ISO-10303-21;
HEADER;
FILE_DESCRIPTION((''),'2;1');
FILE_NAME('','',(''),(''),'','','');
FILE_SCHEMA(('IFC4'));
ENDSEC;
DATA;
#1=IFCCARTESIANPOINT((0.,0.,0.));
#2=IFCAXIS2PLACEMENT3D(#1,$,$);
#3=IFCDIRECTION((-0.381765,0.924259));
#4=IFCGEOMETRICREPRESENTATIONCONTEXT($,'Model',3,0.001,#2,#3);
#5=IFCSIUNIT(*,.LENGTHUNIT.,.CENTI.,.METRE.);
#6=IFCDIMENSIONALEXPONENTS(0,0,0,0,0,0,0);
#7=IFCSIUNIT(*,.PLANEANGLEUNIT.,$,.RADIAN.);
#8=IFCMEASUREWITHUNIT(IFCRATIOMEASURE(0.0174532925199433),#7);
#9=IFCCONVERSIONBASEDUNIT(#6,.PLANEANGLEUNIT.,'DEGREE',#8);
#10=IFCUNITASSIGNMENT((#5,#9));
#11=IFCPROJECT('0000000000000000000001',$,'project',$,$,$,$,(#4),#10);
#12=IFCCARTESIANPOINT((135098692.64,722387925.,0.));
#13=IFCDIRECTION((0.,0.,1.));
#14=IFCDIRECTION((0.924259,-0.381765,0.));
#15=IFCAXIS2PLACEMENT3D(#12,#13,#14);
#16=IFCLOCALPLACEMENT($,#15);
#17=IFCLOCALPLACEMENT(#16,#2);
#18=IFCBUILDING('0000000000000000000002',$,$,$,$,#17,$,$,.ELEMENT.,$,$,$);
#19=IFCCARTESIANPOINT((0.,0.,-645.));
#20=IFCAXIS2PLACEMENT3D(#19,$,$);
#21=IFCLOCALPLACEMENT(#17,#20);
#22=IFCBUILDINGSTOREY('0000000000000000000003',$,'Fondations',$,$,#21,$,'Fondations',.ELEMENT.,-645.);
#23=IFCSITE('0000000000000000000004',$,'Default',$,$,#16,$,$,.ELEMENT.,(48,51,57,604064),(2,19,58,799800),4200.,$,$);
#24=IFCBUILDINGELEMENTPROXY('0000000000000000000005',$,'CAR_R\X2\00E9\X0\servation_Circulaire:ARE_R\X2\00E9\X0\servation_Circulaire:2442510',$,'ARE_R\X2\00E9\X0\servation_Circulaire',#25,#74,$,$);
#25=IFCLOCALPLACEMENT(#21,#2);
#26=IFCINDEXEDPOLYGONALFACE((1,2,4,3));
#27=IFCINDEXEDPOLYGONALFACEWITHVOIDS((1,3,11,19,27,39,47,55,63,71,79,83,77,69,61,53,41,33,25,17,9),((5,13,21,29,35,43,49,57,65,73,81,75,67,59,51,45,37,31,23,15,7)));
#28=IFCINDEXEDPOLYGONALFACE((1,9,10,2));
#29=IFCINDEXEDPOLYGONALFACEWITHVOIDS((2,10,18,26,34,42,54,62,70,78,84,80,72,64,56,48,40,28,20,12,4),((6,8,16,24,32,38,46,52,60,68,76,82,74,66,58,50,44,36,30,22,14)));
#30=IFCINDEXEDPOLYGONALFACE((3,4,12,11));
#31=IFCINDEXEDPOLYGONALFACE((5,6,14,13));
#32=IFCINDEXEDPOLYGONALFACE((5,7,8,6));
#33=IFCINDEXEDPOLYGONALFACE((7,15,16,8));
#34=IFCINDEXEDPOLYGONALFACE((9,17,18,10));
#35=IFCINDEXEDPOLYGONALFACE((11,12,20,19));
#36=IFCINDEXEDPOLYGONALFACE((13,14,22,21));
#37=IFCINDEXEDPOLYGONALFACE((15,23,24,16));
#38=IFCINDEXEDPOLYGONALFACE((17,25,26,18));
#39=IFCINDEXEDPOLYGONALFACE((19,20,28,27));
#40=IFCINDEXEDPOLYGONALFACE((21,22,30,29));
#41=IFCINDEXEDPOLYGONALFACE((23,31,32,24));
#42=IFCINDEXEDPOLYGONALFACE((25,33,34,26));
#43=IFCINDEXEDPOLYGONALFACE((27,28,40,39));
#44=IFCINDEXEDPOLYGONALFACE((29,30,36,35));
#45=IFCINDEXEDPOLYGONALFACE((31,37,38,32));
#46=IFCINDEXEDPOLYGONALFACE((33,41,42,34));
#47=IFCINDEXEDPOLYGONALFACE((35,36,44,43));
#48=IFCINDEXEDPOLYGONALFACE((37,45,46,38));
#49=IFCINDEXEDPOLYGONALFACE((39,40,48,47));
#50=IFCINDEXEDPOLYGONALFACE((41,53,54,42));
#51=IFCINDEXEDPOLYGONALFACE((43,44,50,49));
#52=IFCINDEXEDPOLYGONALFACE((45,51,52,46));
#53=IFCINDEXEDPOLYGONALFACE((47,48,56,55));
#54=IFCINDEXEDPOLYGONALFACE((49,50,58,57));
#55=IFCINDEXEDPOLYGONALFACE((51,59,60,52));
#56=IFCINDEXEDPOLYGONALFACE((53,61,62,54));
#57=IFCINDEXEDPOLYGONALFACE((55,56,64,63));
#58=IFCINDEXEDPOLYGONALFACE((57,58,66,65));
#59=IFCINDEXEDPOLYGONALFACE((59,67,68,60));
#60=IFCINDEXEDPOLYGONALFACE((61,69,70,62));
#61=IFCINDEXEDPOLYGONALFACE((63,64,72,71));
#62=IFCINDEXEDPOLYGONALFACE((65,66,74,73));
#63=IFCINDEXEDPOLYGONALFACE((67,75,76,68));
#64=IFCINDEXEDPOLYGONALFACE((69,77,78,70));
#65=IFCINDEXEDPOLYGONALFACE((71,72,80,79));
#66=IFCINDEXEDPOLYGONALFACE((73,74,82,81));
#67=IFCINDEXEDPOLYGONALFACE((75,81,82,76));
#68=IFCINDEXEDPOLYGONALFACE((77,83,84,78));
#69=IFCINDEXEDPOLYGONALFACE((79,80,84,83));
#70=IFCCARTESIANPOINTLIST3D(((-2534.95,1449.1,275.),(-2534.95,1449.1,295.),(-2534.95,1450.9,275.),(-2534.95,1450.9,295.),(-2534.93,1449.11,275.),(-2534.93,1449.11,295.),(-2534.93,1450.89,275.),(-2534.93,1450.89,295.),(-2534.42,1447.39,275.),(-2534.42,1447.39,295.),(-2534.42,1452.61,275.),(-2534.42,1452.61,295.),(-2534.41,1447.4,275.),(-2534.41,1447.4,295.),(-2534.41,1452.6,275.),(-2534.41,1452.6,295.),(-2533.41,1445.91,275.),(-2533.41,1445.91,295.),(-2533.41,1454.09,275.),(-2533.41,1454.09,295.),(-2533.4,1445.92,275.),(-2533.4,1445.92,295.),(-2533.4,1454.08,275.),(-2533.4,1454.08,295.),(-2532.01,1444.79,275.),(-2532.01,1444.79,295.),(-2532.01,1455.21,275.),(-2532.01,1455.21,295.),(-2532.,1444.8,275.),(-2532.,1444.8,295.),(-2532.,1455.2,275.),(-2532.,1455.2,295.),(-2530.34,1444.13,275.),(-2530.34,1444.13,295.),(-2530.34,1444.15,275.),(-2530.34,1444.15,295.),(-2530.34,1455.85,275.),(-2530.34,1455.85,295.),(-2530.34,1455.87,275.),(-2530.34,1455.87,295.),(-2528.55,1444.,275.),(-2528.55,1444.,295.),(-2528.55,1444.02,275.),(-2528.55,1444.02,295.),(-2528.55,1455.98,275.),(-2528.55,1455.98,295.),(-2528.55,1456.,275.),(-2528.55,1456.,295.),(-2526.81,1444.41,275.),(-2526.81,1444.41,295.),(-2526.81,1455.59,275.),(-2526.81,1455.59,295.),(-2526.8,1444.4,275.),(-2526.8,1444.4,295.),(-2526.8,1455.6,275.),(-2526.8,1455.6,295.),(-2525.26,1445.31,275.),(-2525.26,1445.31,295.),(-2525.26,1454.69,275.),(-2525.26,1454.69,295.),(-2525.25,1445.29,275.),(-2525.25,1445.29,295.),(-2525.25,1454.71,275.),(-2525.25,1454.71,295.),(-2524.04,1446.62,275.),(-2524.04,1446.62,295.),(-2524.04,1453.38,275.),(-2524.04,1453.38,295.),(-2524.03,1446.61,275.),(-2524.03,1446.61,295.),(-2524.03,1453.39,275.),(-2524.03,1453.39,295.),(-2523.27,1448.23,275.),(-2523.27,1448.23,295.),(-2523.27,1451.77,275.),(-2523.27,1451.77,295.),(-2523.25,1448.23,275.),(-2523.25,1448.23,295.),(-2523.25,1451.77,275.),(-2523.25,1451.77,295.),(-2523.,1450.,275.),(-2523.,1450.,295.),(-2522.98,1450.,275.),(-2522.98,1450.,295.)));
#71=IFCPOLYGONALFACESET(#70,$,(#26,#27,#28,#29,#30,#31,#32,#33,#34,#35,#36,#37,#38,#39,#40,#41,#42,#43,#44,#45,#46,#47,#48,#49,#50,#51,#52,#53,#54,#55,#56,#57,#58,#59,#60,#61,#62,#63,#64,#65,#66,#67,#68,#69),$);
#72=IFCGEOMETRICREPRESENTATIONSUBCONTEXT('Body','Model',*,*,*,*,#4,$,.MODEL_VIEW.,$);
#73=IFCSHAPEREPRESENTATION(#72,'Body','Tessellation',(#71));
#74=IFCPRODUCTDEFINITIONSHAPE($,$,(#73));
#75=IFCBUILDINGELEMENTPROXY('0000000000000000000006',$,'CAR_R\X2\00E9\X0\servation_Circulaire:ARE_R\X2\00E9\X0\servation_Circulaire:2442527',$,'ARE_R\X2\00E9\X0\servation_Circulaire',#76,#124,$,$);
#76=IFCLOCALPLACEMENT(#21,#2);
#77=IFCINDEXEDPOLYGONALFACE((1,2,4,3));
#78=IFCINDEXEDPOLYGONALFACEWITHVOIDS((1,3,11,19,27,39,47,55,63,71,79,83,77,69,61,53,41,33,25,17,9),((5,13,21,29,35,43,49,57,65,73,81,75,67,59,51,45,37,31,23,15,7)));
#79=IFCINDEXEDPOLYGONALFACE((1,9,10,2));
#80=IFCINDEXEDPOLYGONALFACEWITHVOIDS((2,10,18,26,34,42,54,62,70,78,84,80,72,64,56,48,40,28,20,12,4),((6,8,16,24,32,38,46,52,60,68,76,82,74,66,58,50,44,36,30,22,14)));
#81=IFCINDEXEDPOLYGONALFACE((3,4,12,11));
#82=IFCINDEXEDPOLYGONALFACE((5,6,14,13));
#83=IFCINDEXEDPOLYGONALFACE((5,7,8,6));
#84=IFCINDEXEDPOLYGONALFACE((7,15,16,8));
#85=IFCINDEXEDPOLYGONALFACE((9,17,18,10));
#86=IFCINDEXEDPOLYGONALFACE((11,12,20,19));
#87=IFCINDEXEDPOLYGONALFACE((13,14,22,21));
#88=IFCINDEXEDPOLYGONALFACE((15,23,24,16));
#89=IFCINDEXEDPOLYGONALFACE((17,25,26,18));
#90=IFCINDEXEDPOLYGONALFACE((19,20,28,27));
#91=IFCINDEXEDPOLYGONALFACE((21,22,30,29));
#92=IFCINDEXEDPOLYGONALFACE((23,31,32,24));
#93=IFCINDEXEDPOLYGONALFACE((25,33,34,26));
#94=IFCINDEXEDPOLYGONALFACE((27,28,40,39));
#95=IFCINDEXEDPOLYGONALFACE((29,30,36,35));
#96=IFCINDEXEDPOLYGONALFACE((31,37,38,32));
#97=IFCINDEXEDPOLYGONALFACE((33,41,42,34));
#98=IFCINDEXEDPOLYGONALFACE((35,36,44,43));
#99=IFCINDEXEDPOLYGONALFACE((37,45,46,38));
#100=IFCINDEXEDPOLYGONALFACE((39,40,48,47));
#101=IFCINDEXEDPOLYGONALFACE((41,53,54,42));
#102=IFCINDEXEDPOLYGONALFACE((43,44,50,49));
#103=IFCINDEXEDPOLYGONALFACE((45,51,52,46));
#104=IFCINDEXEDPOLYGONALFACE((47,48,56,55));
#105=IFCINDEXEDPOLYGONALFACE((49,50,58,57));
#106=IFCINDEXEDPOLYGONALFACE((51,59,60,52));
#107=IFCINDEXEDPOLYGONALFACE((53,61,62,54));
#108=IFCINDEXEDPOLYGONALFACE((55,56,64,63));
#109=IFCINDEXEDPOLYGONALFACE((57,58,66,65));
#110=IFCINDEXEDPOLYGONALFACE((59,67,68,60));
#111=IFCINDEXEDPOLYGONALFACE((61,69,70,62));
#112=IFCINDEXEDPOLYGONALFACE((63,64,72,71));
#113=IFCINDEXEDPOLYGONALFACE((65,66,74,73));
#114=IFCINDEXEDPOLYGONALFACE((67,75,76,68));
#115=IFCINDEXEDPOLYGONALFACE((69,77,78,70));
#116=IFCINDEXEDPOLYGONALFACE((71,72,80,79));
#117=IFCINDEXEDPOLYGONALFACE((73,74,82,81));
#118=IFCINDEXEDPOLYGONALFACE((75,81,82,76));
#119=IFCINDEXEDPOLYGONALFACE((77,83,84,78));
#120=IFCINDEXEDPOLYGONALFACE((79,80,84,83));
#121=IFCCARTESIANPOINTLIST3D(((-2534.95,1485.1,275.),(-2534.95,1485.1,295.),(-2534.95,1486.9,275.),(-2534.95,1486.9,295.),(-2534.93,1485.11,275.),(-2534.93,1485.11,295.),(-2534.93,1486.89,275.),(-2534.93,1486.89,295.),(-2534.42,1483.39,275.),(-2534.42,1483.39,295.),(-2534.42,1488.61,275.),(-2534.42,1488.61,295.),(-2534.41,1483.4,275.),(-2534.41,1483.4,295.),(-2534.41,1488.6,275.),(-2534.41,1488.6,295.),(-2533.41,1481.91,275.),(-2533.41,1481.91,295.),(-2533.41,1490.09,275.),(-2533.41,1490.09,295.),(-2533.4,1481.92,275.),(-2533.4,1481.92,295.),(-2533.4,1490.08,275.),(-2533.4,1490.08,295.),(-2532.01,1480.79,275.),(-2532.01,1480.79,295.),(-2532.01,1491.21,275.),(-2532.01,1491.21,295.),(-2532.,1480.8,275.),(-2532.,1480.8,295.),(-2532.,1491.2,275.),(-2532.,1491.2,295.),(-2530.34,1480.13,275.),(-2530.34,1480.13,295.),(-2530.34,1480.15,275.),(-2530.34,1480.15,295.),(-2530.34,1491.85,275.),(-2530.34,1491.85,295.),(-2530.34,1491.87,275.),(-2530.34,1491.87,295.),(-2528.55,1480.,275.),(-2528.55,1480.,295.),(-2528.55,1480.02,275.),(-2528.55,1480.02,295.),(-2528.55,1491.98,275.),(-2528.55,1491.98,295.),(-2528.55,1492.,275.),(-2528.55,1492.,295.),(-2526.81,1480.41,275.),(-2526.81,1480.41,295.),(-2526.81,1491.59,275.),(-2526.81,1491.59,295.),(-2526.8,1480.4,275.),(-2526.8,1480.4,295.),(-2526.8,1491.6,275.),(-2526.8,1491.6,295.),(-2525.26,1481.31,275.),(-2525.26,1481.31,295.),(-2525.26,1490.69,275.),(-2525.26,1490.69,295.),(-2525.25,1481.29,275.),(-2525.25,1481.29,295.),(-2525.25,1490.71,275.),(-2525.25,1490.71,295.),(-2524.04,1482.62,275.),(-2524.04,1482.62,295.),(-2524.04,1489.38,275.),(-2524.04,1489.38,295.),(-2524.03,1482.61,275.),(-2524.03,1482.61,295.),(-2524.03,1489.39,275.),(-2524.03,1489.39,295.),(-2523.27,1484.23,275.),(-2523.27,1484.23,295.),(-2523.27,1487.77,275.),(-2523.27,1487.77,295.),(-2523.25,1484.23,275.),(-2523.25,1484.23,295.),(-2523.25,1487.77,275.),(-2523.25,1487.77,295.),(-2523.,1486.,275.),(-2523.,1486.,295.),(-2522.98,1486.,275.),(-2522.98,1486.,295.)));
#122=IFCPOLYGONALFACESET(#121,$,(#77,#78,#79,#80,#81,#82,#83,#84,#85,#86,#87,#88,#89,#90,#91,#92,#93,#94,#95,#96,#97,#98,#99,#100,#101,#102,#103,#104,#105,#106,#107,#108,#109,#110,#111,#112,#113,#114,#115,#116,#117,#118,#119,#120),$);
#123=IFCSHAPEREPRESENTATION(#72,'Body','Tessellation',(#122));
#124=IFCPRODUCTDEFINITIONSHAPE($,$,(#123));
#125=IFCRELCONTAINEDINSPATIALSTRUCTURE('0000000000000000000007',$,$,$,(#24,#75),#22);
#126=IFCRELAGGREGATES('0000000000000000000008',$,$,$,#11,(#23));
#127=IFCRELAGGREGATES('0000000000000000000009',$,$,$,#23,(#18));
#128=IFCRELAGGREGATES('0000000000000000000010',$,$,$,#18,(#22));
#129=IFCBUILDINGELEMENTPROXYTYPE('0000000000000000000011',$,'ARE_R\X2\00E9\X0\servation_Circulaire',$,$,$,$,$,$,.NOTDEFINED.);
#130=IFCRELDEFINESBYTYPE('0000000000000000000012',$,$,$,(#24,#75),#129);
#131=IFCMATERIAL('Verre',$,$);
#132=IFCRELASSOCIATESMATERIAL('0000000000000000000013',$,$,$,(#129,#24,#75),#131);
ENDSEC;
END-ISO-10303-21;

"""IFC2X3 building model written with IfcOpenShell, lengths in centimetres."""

from ifc_helpers import new_model, entity, si_unit, converted_unit, direction, frame, frame_2d, origin, place, context, subcontext, project, spatial, hollow_circle, extrude, source, transform, mapped, material, type_object, type_shapes, element, save


model = new_model("IFC2X3")

# Units and contexts
model_context = context("Model", 3, precision=0.001, world=origin(), true_north=direction((-0.381765, 0.924259)))
body_context = subcontext(model_context, "Body", "Model", "MODEL_VIEW")
ifc_project = project(units=[si_unit("LENGTHUNIT", "METRE", prefix="CENTI"), converted_unit("PLANEANGLEUNIT", "DEGREE", entity("IfcRatioMeasure", 0.0174532925199433), si_unit("PLANEANGLEUNIT", "RADIAN"), dimensions=[0, 0, 0, 0, 0, 0, 0])], contexts=[model_context])

# Site, building, storey
site_placement = place(None, frame((135098692.64, 722387925.0, 0.0), z_axis=(0.0, 0.0, 1.0), x_axis=(0.924259, -0.381765, 0.0)))
site = spatial("IfcSite", under=ifc_project, at=site_placement, Name="Default", CompositionType="ELEMENT", RefLatitude=(48, 51, 57, 604064), RefLongitude=(2, 19, 58, 799800), RefElevation=4200.0)
building_placement = place(site_placement, origin())
building = spatial("IfcBuilding", under=site, at=building_placement, CompositionType="ELEMENT")
storey_placement = place(building_placement, frame((0.0, 0.0, -645.0)))
storey = spatial("IfcBuildingStorey", under=building, at=storey_placement, Name="Fondations", LongName="Fondations", CompositionType="ELEMENT", Elevation=-645.0)

# Building element proxies
ifc_material_1 = material(Name="Verre")
building_element_proxy_type_1 = type_object("IfcBuildingElementProxyType", Name="ARE_Réservation_Circulaire", PredefinedType="NOTDEFINED", material=ifc_material_1)
shared_shape_1 = source(origin(), body_context, "Body", "SweptSolid", [
    extrude(hollow_circle(Radius=6.02, WallThickness=0.02, at=frame_2d((0.0, 0.0), x_axis=(1.0, 0.0))), frame((0.0, 0.0, -20.0)), (0.0, 0.0, 1.0), 20.0),
])
type_shapes(building_element_proxy_type_1, [shared_shape_1])
for number, where, name in (
    (1, (-2529.0, 1450.0, 295.0), "CAR_Réservation_Circulaire:ARE_Réservation_Circulaire:2442510"),
    (2, (-2529.0, 1486.0, 295.0), "CAR_Réservation_Circulaire:ARE_Réservation_Circulaire:2442527"),
):
    element("IfcBuildingElementProxy", number, at=place(storey_placement, frame(where)), inside=storey, type_object=building_element_proxy_type_1, material=ifc_material_1, Name=name, ObjectType="ARE_Réservation_Circulaire", context=body_context, shape_type="MappedRepresentation", body=[
        mapped(shared_shape_1, transform((0.0, 0.0, 0.0), scale=1.0)),
    ])

save(model, "model.ifc")
